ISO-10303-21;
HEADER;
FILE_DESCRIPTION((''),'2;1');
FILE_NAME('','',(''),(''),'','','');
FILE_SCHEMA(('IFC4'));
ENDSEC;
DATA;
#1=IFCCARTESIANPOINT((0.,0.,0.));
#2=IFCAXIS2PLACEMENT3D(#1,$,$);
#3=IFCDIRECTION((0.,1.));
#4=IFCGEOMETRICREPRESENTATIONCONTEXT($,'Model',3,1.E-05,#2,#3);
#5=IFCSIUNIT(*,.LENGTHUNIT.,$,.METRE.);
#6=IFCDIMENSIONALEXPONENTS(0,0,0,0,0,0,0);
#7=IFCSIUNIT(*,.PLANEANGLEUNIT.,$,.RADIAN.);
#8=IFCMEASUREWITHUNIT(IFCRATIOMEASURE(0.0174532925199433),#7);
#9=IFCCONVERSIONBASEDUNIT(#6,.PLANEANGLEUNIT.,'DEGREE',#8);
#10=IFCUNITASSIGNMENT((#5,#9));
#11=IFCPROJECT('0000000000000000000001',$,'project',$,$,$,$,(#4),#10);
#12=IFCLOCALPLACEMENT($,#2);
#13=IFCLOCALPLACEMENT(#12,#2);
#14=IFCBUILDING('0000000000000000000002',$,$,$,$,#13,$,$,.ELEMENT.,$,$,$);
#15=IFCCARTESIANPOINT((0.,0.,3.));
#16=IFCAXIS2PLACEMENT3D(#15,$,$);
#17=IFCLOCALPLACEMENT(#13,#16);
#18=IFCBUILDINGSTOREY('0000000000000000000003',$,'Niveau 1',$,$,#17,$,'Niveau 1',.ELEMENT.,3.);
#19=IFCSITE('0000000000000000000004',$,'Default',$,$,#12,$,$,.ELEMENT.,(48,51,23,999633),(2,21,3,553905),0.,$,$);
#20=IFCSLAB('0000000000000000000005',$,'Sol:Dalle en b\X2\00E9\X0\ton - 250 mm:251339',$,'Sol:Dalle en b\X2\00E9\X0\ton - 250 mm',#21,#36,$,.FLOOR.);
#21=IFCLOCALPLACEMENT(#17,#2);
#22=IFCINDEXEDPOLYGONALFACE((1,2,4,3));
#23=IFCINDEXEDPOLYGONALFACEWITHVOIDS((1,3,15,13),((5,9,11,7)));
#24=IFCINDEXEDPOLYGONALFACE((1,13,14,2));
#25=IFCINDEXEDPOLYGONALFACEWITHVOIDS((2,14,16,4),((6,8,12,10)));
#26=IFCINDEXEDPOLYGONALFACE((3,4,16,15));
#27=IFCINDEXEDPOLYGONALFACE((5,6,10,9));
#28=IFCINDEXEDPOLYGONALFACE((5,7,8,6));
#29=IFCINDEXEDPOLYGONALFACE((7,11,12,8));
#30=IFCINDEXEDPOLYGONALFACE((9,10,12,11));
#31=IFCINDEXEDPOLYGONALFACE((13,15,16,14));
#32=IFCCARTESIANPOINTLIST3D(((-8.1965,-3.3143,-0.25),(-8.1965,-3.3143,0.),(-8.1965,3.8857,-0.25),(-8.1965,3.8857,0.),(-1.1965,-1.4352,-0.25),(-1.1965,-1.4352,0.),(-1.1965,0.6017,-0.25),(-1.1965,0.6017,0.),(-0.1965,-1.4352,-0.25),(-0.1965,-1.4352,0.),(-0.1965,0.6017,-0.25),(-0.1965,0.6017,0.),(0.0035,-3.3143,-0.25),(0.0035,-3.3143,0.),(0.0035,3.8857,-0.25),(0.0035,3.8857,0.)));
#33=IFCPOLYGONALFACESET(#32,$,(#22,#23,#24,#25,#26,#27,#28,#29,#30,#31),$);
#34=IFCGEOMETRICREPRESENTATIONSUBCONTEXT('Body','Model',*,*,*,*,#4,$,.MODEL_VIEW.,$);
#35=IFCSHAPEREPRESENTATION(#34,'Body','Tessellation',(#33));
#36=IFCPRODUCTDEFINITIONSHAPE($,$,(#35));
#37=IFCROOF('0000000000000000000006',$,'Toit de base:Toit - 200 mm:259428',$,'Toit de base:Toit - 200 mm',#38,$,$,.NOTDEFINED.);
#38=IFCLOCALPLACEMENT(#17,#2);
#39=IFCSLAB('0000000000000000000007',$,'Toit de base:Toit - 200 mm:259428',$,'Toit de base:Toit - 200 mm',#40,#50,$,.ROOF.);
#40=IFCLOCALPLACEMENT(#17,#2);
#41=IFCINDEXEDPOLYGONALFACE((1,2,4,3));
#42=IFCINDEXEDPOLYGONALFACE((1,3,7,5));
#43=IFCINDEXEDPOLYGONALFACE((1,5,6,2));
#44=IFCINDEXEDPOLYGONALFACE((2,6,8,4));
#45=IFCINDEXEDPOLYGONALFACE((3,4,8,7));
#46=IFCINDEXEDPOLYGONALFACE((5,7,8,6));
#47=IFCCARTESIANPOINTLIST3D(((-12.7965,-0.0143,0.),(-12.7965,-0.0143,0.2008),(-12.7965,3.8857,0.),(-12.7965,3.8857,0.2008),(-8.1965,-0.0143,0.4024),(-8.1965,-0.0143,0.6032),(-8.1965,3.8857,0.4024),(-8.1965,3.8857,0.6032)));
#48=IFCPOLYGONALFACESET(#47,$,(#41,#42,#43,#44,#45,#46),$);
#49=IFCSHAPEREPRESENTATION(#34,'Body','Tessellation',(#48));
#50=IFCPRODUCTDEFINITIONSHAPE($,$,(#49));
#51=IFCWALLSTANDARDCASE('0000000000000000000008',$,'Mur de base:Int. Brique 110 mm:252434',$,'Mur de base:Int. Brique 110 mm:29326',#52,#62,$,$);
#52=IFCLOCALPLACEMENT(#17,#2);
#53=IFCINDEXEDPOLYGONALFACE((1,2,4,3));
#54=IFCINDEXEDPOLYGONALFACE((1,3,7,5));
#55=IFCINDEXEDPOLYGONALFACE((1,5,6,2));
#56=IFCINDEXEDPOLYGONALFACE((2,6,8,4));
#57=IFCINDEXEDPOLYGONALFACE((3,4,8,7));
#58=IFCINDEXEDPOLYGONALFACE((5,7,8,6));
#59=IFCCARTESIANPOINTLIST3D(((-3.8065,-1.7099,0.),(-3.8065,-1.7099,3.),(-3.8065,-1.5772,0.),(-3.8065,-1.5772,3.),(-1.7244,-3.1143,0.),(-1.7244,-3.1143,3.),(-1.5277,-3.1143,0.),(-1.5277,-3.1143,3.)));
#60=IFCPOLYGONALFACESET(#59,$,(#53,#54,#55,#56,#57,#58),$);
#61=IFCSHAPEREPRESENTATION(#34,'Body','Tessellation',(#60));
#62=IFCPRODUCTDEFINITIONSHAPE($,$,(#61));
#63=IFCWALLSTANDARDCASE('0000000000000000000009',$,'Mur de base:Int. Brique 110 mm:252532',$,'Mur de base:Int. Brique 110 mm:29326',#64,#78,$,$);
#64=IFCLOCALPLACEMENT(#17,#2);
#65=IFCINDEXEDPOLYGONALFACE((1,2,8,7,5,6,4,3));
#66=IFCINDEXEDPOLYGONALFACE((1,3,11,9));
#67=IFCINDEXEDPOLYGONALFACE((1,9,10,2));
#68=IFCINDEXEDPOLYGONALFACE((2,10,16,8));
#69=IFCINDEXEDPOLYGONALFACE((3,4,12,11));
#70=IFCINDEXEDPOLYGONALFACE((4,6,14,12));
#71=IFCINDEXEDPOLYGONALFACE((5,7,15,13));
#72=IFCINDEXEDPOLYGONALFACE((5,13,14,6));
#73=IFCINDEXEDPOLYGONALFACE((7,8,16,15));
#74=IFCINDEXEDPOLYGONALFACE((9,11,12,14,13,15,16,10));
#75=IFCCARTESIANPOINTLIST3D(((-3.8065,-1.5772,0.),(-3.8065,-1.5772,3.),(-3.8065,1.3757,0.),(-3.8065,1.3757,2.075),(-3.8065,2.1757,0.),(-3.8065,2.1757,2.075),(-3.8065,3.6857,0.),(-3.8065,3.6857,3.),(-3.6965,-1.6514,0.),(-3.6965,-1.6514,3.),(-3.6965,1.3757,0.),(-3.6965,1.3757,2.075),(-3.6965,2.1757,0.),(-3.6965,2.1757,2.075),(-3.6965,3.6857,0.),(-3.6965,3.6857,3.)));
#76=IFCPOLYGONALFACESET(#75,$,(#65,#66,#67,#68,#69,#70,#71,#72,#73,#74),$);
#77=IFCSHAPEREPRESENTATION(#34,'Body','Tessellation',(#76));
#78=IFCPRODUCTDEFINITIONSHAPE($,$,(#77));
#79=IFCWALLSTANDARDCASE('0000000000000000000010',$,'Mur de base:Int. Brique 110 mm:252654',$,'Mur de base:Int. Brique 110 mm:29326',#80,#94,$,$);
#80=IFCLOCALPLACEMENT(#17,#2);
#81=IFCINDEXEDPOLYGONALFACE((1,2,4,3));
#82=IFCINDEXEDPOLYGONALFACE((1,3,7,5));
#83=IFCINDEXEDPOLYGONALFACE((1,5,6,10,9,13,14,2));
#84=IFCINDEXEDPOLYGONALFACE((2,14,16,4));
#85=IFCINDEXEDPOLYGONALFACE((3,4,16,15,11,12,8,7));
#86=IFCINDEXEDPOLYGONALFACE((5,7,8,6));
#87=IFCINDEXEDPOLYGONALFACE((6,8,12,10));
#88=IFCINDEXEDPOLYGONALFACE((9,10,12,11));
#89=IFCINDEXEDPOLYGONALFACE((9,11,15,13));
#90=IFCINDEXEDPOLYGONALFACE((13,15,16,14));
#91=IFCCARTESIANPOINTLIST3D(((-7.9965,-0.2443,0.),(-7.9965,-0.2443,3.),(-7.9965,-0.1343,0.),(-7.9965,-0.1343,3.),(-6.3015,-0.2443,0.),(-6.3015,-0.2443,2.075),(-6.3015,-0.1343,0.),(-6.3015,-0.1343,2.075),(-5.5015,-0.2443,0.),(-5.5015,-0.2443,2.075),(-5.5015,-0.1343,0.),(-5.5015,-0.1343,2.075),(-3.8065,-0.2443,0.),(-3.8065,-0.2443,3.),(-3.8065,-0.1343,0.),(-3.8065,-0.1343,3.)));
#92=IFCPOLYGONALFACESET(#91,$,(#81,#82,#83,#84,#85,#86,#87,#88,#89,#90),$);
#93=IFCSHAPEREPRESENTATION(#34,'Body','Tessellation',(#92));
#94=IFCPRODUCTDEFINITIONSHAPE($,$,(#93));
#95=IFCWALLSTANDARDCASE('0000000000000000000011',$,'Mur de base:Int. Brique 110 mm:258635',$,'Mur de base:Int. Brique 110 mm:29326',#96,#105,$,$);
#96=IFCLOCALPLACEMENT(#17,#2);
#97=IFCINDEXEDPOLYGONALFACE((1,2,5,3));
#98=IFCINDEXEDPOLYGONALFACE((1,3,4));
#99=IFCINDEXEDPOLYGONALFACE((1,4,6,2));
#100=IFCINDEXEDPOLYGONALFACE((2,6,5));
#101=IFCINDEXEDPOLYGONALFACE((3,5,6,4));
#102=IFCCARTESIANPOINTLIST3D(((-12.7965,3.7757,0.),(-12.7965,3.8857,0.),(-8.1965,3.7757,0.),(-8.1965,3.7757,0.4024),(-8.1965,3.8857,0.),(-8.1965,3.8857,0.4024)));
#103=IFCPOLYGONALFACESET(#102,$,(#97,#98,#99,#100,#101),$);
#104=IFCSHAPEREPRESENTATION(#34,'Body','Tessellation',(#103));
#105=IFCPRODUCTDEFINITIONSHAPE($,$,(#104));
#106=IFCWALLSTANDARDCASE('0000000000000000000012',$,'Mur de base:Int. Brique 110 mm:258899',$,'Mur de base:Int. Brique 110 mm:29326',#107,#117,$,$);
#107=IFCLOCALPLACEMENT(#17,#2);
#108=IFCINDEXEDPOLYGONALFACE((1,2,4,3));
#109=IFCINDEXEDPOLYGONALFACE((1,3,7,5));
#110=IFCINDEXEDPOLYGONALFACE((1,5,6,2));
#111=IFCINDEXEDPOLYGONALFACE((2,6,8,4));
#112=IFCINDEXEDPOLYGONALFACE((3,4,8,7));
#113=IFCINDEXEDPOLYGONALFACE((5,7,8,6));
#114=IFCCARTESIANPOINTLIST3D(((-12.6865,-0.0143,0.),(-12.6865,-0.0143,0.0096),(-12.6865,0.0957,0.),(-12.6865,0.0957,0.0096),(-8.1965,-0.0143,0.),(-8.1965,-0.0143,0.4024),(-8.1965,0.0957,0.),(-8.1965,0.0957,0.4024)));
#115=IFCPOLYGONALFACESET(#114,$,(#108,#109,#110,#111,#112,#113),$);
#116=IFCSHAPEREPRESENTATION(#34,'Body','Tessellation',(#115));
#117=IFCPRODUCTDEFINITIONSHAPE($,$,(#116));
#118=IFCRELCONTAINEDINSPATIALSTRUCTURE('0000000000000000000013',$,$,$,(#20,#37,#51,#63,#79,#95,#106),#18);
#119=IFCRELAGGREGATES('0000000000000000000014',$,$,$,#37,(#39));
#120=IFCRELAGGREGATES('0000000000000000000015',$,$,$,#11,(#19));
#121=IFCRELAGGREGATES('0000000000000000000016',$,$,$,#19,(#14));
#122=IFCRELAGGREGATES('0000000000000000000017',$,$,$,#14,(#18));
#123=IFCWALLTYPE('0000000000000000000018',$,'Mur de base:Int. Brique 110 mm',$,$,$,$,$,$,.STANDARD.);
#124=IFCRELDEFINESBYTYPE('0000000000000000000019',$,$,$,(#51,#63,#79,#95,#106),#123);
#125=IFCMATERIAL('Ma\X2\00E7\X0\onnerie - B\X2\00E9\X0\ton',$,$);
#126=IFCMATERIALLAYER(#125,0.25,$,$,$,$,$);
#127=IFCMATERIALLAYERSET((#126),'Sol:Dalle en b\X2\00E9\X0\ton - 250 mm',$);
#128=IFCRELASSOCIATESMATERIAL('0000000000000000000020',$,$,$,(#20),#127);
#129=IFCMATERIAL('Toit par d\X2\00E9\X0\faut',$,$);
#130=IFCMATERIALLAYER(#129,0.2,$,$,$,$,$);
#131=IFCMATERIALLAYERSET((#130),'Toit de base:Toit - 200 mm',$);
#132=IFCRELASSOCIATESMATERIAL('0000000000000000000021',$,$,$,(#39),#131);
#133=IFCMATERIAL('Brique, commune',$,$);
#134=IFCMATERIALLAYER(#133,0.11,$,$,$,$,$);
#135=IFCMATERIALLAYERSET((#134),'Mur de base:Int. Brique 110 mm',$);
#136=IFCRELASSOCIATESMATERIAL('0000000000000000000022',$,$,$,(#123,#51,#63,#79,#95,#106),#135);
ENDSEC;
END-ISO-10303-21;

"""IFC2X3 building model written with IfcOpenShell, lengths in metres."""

from ifc_helpers import new_model, entity, si_unit, converted_unit, direction, frame, frame_2d, origin, origin_2d_with_axis, place, context, subcontext, project, spatial, polyline, rectangle, outline, extrude, clip, halfspace, bounded_halfspace, material, layer, layer_set, layer_usage, type_object, element, aggregate, save


model = new_model("IFC2X3")

# Units and contexts
model_context = context("Model", 3, precision=1e-05, world=origin(), true_north=direction((0.0, 1.0)))
body_context = subcontext(model_context, "Body", "Model", "MODEL_VIEW")
ifc_project = project(units=[si_unit("LENGTHUNIT", "METRE"), converted_unit("PLANEANGLEUNIT", "DEGREE", entity("IfcRatioMeasure", 0.0174532925199433), si_unit("PLANEANGLEUNIT", "RADIAN"), dimensions=[0, 0, 0, 0, 0, 0, 0])], contexts=[model_context])

# Site, building, storey
site_placement = place(None, origin())
site = spatial("IfcSite", under=ifc_project, at=site_placement, Name="Default", CompositionType="ELEMENT", RefLatitude=(48, 51, 23, 999633), RefLongitude=(2, 21, 3, 553905), RefElevation=0.0)
building_placement = place(site_placement, origin())
building = spatial("IfcBuilding", under=site, at=building_placement, CompositionType="ELEMENT")
storey_placement = place(building_placement, frame((0.0, 0.0, 3.0)))
storey = spatial("IfcBuildingStorey", under=building, at=storey_placement, Name="Niveau 1", LongName="Niveau 1", CompositionType="ELEMENT", Elevation=3.0)

# Slab, opening
ifc_material_1 = material(Name="Maçonnerie - Béton")
ifc_layer_1 = layer(ifc_material_1, 0.25)
ifc_layer_set_1 = layer_set([ifc_layer_1], Name="Sol:Dalle en béton - 250 mm")
ifc_layer_usage_1 = layer_usage(ifc_layer_set_1, "AXIS3", "POSITIVE", 0.0)
slab_1_placement = place(storey_placement, frame((-8.1965, -3.3143, -0.25)))
slab_1 = element("IfcSlab", 1, at=slab_1_placement, inside=storey, material=ifc_layer_usage_1, Name="Sol:Dalle en béton - 250 mm:251339", ObjectType="Sol:Dalle en béton - 250 mm", PredefinedType="FLOOR", context=body_context, shape_type="SweptSolid", body=[
    extrude(rectangle(XDim=8.2, YDim=7.2, at=frame_2d((0.0, 0.0), x_axis=(-1.0, 0.0))), frame((4.1, 3.6, 0.25), z_axis=(0.0, 0.0, -1.0), x_axis=(-1.0, 0.0, 0.0)), (0.0, 0.0, 1.0), 0.25),
])
opening_1_placement = place(slab_1_placement, frame((7.5, 2.8975, 0.25)))
element("IfcOpeningElement", 2, at=opening_1_placement, cuts=slab_1, ObjectType="Opening", context=body_context, shape_type="SweptSolid", body=[
    extrude(rectangle(XDim=2.0369, YDim=1.0, at=origin_2d_with_axis()), frame((0.0, 0.0, 0.0), z_axis=(0.0, 0.0, -1.0), x_axis=(0.0, 1.0, 0.0)), (0.0, 0.0, 1.0), 0.25),
])

# Roof, slab
roof_placement = place(storey_placement, frame((-12.7965, -0.0143, 0.0)))
roof = element("IfcRoof", 3, at=roof_placement, inside=storey, Name="Toit de base:Toit - 200 mm:259428", ObjectType="Toit de base:Toit - 200 mm", ShapeType="NOTDEFINED")
ifc_material_2 = material(Name="Toit par défaut")
ifc_layer_2 = layer(ifc_material_2, 0.2)
ifc_layer_set_2 = layer_set([ifc_layer_2], Name="Toit de base:Toit - 200 mm")
slab_2_placement = place(roof_placement, origin())
slab_2 = element("IfcSlab", 4, at=slab_2_placement, material=ifc_layer_set_2, Name="Toit de base:Toit - 200 mm:259428", ObjectType="Toit de base:Toit - 200 mm", PredefinedType="ROOF", context=body_context, shape_type="SweptSolid", body=[
    extrude(rectangle(XDim=4.6176, YDim=3.9, at=origin_2d_with_axis()), frame((2.3, 1.95, 0.2012), z_axis=(-0.087156, 0.0, 0.996195), x_axis=(0.996195, 0.0, 0.087156)), (0.087156, 0.0, 0.996195), 0.2008),
])
aggregate(roof, [slab_2])

# Wall
ifc_material_3 = material(Name="Brique, commune")
ifc_layer_3 = layer(ifc_material_3, 0.11)
ifc_layer_set_3 = layer_set([ifc_layer_3], Name="Mur de base:Int. Brique 110 mm")
ifc_layer_usage_2 = layer_usage(ifc_layer_set_3, "AXIS2", "NEGATIVE", 0.055)
wall_type = type_object("IfcWallType", Name="Mur de base:Int. Brique 110 mm", PredefinedType="STANDARD", material=ifc_layer_set_3)
wall_1_placement = place(storey_placement, frame((-1.5584, -3.1599, 0.0), z_axis=(0.0, 0.0, 1.0), x_axis=(-0.829038, 0.559193, 0.0)))
element("IfcWallStandardCase", 5, at=wall_1_placement, inside=storey, type_object=wall_type, material=ifc_layer_usage_2, Name="Mur de base:Int. Brique 110 mm:252434", ObjectType="Mur de base:Int. Brique 110 mm:29326", context=body_context, shape_type="Clipping", body=[
    clip(extrude(outline(polyline([(2.7488, -0.055), (2.6746, 0.055), (0.1631, 0.055), (0.0, -0.055), (2.6161, -0.055), (2.7488, -0.055)])), origin(), (0.0, 0.0, 1.0), 3.0), halfspace(origin(), True)),
])

# Walls, openings
ifc_layer_usage_3 = layer_usage(ifc_layer_set_3, "AXIS2", "NEGATIVE", 0.055)
wall_2_placement = place(storey_placement, frame((-3.7515, -1.6514, 0.0), z_axis=(0.0, 0.0, 1.0), x_axis=(0.0, 1.0, 0.0)))
wall_2 = element("IfcWallStandardCase", 6, at=wall_2_placement, inside=storey, type_object=wall_type, material=ifc_layer_usage_3, Name="Mur de base:Int. Brique 110 mm:252532", ObjectType="Mur de base:Int. Brique 110 mm:29326", context=body_context, shape_type="Clipping", body=[
    clip(extrude(outline(polyline([(0.0, -0.055), (5.3371, -0.055), (5.3371, 0.055), (1.5171, 0.055), (1.4071, 0.055), (0.0742, 0.055), (0.0, -0.055)])), origin(), (0.0, 0.0, 1.0), 3.0), halfspace(origin(), True)),
])
opening_2_placement = place(wall_2_placement, frame((3.0271, -0.055, 0.0)))
element("IfcOpeningElement", 7, at=opening_2_placement, cuts=wall_2, ObjectType="Opening", context=body_context, shape_type="SweptSolid", body=[
    extrude(rectangle(XDim=2.075, YDim=0.8, at=frame_2d((1.0375, 0.4), x_axis=(1.0, 0.0))), frame((0.0, 0.0, 0.0), z_axis=(0.0, 1.0, 0.0), x_axis=(0.0, 0.0, 1.0)), (0.0, 0.0, 1.0), 0.11),
])
ifc_layer_usage_4 = layer_usage(ifc_layer_set_3, "AXIS2", "NEGATIVE", 0.055)
wall_3_placement = place(storey_placement, frame((-3.8065, -0.1893, 0.0), z_axis=(0.0, 0.0, 1.0), x_axis=(-1.0, 0.0, 0.0)))
wall_3 = element("IfcWallStandardCase", 8, at=wall_3_placement, inside=storey, type_object=wall_type, material=ifc_layer_usage_4, Name="Mur de base:Int. Brique 110 mm:252654", ObjectType="Mur de base:Int. Brique 110 mm:29326", context=body_context, shape_type="Clipping", body=[
    clip(extrude(rectangle(XDim=4.19, YDim=0.11, at=frame_2d((2.095, 0.0), x_axis=(-1.0, 0.0))), origin(), (0.0, 0.0, 1.0), 3.0), halfspace(origin(), True)),
])
opening_3_placement = place(wall_3_placement, frame((1.695, -0.055, 0.0)))
element("IfcOpeningElement", 9, at=opening_3_placement, cuts=wall_3, ObjectType="Opening", context=body_context, shape_type="SweptSolid", body=[
    extrude(rectangle(XDim=2.075, YDim=0.8, at=frame_2d((1.0375, 0.4), x_axis=(1.0, 0.0))), frame((0.0, 0.0, 0.0), z_axis=(0.0, 1.0, 0.0), x_axis=(0.0, 0.0, 1.0)), (0.0, 0.0, 1.0), 0.11),
])

# Walls
ifc_layer_usage_5 = layer_usage(ifc_layer_set_3, "AXIS2", "NEGATIVE", 0.055)
wall_4_placement = place(storey_placement, frame((-8.1965, 3.8307, 0.0), z_axis=(0.0, 0.0, 1.0), x_axis=(-1.0, 0.0, 0.0)))
element("IfcWallStandardCase", 10, at=wall_4_placement, inside=storey, type_object=wall_type, material=ifc_layer_usage_5, Name="Mur de base:Int. Brique 110 mm:258635", ObjectType="Mur de base:Int. Brique 110 mm:29326", context=body_context, shape_type="Clipping", body=[
    clip(clip(extrude(rectangle(XDim=4.6, YDim=0.11, at=frame_2d((2.3, 0.0), x_axis=(-1.0, 0.0))), origin(), (0.0, 0.0, 1.0), 0.4024), bounded_halfspace(frame((0.0, -0.055, 0.4024), z_axis=(0.087156, 0.0, 0.996195), x_axis=(0.0, 1.0, 0.0)), False, frame((0.0, -0.055, 0.4024)), polyline([(0.0, 0.0), (4.6, 0.0), (4.6, 0.11), (0.0, 0.11), (0.0, 0.0)]))), halfspace(frame((0.0, 0.0, -3.0)), True)),
])
ifc_layer_usage_6 = layer_usage(ifc_layer_set_3, "AXIS2", "NEGATIVE", 0.055)
wall_5_placement = place(storey_placement, frame((-12.6865, 0.0407, 0.0)))
element("IfcWallStandardCase", 11, at=wall_5_placement, inside=storey, type_object=wall_type, material=ifc_layer_usage_6, Name="Mur de base:Int. Brique 110 mm:258899", ObjectType="Mur de base:Int. Brique 110 mm:29326", context=body_context, shape_type="Clipping", body=[
    clip(clip(extrude(rectangle(XDim=4.49, YDim=0.11, at=frame_2d((2.245, 0.0), x_axis=(-1.0, 0.0))), origin(), (0.0, 0.0, 1.0), 0.4024), bounded_halfspace(frame((0.0, -0.055, 0.0096), z_axis=(-0.087156, 0.0, 0.996195), x_axis=(0.0, -1.0, 0.0)), False, frame((0.0, -0.055, 0.0096)), polyline([(0.0, 0.0), (4.49, 0.0), (4.49, 0.11), (0.0, 0.11), (0.0, 0.0)]))), halfspace(frame((0.0, 0.0, -3.0)), True)),
])

save(model, "model.ifc")
